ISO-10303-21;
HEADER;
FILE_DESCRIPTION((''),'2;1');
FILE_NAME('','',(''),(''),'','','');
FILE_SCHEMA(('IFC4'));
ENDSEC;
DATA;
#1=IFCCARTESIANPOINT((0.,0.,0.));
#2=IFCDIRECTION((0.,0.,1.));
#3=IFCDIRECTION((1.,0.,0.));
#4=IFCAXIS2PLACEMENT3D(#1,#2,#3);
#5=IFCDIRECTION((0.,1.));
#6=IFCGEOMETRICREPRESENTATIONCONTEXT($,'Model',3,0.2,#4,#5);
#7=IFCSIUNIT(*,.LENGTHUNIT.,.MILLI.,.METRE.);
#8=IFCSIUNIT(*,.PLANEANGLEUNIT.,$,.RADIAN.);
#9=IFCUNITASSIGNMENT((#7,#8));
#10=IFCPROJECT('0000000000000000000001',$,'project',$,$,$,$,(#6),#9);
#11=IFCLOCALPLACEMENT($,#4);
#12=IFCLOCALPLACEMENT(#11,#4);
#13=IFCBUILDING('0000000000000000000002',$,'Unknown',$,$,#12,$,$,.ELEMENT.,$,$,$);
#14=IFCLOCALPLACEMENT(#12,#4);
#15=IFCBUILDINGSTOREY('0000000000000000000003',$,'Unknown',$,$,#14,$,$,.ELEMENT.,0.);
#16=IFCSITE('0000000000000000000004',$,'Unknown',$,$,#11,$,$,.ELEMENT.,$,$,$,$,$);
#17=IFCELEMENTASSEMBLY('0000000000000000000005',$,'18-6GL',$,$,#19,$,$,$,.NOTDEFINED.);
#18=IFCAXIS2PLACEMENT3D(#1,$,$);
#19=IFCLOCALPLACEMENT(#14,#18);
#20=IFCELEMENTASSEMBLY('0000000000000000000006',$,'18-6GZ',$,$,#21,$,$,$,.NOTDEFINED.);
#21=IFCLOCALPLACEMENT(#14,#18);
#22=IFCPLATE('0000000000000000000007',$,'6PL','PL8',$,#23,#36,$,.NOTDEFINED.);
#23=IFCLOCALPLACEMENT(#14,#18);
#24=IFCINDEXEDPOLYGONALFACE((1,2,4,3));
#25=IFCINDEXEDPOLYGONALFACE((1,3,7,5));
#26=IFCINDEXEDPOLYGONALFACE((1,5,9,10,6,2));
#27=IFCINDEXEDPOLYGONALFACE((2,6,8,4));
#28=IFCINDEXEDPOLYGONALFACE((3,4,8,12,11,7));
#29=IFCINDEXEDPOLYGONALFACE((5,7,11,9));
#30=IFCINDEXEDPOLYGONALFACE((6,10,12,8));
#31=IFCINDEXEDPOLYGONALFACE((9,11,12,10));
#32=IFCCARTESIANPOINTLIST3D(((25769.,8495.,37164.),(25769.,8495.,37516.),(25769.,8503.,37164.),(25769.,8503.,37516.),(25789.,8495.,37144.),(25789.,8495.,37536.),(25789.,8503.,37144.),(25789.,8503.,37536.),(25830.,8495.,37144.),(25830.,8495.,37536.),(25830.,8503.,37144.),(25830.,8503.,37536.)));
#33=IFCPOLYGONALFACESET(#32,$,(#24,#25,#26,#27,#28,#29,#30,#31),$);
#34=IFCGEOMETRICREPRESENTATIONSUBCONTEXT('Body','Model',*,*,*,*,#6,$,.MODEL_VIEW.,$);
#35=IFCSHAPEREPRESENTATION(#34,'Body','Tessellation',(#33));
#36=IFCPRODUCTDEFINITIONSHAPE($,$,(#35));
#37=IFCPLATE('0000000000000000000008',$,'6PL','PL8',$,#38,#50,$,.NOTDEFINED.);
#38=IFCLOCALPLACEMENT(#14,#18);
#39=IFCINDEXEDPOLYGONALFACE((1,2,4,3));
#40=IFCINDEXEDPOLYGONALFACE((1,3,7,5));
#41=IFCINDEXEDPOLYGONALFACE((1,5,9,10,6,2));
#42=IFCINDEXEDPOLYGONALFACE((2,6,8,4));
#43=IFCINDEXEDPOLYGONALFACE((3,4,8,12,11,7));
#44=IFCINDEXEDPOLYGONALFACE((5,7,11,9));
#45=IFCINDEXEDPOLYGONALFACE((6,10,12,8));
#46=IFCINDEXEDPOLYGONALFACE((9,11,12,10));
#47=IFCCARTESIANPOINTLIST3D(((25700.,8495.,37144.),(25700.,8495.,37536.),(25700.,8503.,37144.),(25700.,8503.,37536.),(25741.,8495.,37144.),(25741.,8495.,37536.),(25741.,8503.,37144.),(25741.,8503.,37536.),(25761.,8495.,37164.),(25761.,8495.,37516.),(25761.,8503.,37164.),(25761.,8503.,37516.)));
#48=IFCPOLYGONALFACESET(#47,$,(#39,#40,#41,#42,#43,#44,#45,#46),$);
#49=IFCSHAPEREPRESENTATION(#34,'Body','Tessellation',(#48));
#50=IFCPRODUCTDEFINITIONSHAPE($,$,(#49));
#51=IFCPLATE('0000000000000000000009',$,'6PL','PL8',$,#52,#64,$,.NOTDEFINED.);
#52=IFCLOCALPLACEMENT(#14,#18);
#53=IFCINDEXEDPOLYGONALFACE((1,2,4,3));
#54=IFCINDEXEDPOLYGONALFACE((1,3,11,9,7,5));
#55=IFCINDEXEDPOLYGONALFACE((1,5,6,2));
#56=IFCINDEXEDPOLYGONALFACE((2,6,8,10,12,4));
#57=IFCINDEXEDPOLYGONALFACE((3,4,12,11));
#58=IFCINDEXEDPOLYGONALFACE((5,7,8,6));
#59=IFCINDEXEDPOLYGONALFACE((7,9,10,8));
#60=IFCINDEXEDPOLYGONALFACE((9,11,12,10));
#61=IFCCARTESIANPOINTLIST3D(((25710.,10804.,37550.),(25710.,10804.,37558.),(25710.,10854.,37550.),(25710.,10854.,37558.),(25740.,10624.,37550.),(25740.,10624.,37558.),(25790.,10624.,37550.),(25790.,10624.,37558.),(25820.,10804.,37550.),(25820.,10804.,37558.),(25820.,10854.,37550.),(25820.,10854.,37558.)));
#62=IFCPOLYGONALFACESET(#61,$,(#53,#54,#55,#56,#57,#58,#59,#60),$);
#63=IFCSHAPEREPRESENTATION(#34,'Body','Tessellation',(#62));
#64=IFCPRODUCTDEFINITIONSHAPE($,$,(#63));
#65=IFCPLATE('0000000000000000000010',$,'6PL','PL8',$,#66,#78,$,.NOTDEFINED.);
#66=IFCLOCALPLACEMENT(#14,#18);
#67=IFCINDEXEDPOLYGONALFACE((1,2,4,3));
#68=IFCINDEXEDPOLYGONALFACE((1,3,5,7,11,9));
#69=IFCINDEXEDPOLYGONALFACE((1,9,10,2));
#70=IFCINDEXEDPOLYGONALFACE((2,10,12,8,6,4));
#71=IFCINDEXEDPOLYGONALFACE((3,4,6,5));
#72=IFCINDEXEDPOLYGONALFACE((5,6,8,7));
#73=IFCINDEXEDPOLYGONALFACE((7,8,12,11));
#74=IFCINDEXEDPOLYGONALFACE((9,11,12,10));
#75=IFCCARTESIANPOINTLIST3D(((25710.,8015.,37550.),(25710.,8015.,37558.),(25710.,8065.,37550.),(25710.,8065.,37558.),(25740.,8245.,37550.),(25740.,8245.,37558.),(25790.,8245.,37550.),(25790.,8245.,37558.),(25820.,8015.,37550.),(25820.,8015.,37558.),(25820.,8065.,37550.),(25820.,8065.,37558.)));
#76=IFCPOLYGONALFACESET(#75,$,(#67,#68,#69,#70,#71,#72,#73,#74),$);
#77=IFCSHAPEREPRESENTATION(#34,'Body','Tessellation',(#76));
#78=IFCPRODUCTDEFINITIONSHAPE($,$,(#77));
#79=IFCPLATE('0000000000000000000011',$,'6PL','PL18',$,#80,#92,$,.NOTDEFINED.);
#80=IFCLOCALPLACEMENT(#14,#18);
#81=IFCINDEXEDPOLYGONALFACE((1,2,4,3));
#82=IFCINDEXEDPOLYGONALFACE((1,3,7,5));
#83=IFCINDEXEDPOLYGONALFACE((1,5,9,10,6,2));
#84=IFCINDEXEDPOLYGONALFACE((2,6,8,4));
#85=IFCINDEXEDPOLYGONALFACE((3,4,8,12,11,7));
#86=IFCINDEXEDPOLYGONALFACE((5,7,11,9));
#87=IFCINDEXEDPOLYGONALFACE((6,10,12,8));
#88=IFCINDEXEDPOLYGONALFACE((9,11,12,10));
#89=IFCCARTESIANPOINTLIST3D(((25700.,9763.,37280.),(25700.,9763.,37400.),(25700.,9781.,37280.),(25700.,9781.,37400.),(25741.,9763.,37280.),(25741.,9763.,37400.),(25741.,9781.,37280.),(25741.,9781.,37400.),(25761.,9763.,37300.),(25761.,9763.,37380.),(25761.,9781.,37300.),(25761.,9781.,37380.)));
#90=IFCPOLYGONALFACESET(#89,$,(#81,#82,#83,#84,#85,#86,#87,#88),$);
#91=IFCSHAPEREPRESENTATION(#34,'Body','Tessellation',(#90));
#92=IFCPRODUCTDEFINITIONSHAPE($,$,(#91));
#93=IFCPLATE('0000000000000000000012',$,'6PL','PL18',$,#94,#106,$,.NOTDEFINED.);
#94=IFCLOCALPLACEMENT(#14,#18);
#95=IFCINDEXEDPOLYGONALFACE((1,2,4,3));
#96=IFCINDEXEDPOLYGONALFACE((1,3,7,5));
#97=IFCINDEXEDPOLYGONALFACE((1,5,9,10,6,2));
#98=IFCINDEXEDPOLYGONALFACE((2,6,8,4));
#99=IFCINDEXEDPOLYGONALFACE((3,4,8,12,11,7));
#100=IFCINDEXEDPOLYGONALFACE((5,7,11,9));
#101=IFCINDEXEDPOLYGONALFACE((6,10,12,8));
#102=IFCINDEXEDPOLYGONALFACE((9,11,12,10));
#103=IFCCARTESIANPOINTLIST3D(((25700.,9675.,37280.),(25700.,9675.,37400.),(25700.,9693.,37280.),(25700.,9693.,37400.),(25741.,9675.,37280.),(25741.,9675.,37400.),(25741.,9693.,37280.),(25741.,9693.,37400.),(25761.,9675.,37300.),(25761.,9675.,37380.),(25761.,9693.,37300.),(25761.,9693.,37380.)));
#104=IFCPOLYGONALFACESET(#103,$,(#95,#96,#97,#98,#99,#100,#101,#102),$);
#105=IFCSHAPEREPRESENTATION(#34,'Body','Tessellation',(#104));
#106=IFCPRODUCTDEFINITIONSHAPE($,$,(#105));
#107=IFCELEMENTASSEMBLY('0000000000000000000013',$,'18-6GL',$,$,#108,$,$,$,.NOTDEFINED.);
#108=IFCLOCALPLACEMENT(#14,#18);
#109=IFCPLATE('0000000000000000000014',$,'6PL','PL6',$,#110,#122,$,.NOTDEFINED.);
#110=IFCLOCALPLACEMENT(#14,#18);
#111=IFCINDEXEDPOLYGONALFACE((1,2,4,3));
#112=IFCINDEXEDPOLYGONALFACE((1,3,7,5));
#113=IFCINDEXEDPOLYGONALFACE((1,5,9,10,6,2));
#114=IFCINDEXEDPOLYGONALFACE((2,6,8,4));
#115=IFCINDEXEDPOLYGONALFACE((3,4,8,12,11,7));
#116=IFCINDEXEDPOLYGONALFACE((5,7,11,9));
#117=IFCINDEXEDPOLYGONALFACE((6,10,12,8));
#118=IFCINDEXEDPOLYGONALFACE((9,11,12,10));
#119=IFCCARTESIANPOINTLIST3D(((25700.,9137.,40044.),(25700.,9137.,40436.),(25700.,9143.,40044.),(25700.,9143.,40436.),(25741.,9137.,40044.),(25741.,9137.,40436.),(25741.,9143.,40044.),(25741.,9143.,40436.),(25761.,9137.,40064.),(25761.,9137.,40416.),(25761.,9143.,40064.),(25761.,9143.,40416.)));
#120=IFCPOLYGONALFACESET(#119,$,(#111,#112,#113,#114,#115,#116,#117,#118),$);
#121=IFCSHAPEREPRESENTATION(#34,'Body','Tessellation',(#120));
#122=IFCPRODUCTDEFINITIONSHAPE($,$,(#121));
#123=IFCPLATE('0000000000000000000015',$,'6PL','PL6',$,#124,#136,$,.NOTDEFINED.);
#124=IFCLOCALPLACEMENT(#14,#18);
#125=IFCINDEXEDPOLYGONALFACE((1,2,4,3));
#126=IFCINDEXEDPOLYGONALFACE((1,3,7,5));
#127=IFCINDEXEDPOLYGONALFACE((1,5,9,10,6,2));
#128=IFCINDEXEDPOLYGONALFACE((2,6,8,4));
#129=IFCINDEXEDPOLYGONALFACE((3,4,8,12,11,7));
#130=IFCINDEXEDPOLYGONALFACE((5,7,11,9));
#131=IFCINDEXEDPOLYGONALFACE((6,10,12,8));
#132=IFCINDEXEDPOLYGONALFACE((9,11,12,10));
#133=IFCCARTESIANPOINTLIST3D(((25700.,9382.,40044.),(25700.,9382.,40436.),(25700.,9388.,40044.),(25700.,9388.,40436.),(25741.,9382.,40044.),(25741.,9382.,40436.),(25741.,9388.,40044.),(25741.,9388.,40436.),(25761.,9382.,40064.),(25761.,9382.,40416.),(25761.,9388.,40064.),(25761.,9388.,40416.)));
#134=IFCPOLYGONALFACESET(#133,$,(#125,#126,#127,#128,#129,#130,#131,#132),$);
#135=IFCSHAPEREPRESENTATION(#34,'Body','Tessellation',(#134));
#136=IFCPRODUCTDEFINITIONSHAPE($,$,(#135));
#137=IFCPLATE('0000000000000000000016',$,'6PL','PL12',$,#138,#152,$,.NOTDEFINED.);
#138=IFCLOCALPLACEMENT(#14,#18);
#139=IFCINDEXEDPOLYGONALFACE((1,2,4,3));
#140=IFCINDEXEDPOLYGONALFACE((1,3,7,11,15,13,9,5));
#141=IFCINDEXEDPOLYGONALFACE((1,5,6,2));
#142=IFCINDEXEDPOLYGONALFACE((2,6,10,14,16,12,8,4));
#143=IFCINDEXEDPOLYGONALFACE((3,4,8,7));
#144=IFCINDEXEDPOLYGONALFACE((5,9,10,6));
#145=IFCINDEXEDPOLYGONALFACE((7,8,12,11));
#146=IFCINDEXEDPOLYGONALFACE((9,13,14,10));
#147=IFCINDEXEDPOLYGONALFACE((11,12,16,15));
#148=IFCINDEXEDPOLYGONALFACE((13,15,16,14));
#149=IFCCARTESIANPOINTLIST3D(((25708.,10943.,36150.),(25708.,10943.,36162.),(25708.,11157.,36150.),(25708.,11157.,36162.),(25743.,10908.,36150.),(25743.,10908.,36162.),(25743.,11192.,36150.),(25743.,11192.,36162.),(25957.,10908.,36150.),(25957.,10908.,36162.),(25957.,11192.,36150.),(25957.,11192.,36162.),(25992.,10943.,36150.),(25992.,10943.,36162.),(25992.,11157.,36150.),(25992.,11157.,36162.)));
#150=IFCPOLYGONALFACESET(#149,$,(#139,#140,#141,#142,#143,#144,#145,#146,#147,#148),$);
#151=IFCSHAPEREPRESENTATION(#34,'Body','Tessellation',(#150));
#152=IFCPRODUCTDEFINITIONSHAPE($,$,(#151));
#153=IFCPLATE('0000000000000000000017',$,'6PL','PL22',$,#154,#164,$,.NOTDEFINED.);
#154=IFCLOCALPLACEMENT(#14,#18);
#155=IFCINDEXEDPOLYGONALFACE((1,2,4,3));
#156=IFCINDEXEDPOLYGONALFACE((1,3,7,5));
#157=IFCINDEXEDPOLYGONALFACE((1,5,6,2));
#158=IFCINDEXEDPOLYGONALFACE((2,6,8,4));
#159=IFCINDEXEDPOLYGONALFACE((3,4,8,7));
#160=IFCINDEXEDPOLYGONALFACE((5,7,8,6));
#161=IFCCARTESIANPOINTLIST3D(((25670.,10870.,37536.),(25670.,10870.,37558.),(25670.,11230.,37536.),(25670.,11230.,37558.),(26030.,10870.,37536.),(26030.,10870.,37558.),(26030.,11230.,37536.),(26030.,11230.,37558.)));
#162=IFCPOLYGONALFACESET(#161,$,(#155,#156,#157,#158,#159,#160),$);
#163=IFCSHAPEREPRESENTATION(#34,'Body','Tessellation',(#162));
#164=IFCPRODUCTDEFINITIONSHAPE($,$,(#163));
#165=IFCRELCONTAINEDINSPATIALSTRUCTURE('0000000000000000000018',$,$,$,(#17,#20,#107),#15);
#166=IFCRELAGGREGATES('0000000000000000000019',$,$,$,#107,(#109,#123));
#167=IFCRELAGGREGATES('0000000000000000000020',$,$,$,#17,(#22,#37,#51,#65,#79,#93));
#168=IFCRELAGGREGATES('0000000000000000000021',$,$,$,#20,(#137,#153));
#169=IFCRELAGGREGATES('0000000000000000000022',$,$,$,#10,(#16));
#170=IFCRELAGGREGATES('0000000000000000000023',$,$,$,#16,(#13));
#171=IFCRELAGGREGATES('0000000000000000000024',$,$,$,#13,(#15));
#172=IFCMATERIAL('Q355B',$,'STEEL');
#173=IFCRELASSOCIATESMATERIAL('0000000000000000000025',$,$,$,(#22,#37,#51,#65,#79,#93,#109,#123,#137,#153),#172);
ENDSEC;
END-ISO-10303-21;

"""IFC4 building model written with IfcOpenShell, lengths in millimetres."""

from ifc_helpers import new_model, si_unit, direction, frame, origin_with_axes, place, context, subcontext, project, spatial, line, indexed_curve, outline, extrude, material, element, aggregate, save


model = new_model("IFC4")

# Units and contexts
model_context = context("Model", 3, precision=0.2, world=origin_with_axes(), true_north=direction((0.0, 1.0)))
body_context = subcontext(model_context, "Body", "Model", "MODEL_VIEW")
ifc_project = project(units=[si_unit("LENGTHUNIT", "METRE", prefix="MILLI"), si_unit("PLANEANGLEUNIT", "RADIAN")], contexts=[model_context])

# Site, building, storey
site_placement = place(None, origin_with_axes())
site = spatial("IfcSite", under=ifc_project, at=site_placement, Name="Unknown", CompositionType="ELEMENT")
building_placement = place(site_placement, origin_with_axes())
building = spatial("IfcBuilding", under=site, at=building_placement, Name="Unknown", CompositionType="ELEMENT")
storey_placement = place(building_placement, origin_with_axes())
storey = spatial("IfcBuildingStorey", under=building, at=storey_placement, Name="Unknown", CompositionType="ELEMENT", Elevation=0.0)

# Element assembly
assembly_1_placement = place(storey_placement, frame((25765.0, 10900.0, 37340.0), z_axis=(-1.0, 0.0, 0.0), x_axis=(0.0, -1.0, 0.0)))
assembly_1 = element("IfcElementAssembly", 1, at=assembly_1_placement, inside=storey, Name="18-6GL", PredefinedType="NOTDEFINED")
ifc_material_1 = material(Name="Q355B", Category="STEEL")

# Element assembly
assembly_2_placement = place(storey_placement, frame((25850.0, 11050.0, 35950.0), z_axis=(-1.0, 0.0, 0.0), x_axis=(0.0, 0.0, 1.0)))
assembly_2 = element("IfcElementAssembly", 2, at=assembly_2_placement, inside=storey, Name="18-6GZ", PredefinedType="NOTDEFINED")

# Plates
plate_1_placement = place(assembly_1_placement, frame((2401.0, -196.0, -65.0), z_axis=(-1.0, 0.0, 0.0), x_axis=(0.0, 0.0, 1.0)))
plate_1 = element("IfcPlate", 3, at=plate_1_placement, material=ifc_material_1, Name="6PL", Description="PL8", PredefinedType="NOTDEFINED", context=body_context, shape_type="SolidModel", body=[
    extrude(outline(indexed_curve([(0.0, 0.0), (41.0, 0.0), (61.0, 20.0), (61.0, 372.0), (41.0, 392.0), (0.0, 392.0)], segments=[line(1, 2, 3, 4, 5, 6, 1)])), frame((0.0, 0.0, 4.0), z_axis=(0.0, 0.0, 1.0), x_axis=(1.0, 0.0, 0.0)), (0.0, 0.0, -1.0), 8.0),
])
plate_2_placement = place(assembly_1_placement, frame((2401.0, -196.0, 4.0), z_axis=(-1.0, 0.0, 0.0), x_axis=(0.0, 0.0, 1.0)))
plate_2 = element("IfcPlate", 4, at=plate_2_placement, material=ifc_material_1, Name="6PL", Description="PL8", PredefinedType="NOTDEFINED", context=body_context, shape_type="SolidModel", body=[
    extrude(outline(indexed_curve([(0.0, 20.0), (20.0, 0.0), (61.0, 0.0), (61.0, 392.0), (20.0, 392.0), (0.0, 372.0)], segments=[line(1, 2, 3, 4, 5, 6, 1)])), frame((0.0, 0.0, 4.0), z_axis=(0.0, 0.0, 1.0), x_axis=(1.0, 0.0, 0.0)), (0.0, 0.0, -1.0), 8.0),
])
plate_3_placement = place(assembly_1_placement, frame((96.0, 214.0, -55.0), z_axis=(0.0, 1.0, 0.0), x_axis=(-1.0, 0.0, 0.0)))
plate_3 = element("IfcPlate", 5, at=plate_3_placement, material=ifc_material_1, Name="6PL", Description="PL8", PredefinedType="NOTDEFINED", context=body_context, shape_type="SolidModel", body=[
    extrude(outline(indexed_curve([(0.0, 0.0), (50.0, 0.0), (50.0, 110.0), (0.0, 110.0), (-180.0, 80.0), (-180.0, 30.0)], segments=[line(1, 2, 3, 4, 5, 6, 1)])), frame((0.0, 0.0, 4.0), z_axis=(0.0, 0.0, 1.0), x_axis=(1.0, 0.0, 0.0)), (0.0, 0.0, -1.0), 8.0),
])
plate_4_placement = place(assembly_1_placement, frame((2835.0, 214.0, -55.0), z_axis=(0.0, -1.0, 0.0), x_axis=(1.0, 0.0, 0.0)))
plate_4 = element("IfcPlate", 6, at=plate_4_placement, material=ifc_material_1, Name="6PL", Description="PL8", PredefinedType="NOTDEFINED", context=body_context, shape_type="SolidModel", body=[
    extrude(outline(indexed_curve([(0.0, 0.0), (50.0, 0.0), (50.0, 110.0), (0.0, 110.0), (-180.0, 80.0), (-180.0, 30.0)], segments=[line(1, 2, 3, 4, 5, 6, 1)])), frame((0.0, 0.0, 4.0), z_axis=(0.0, 0.0, 1.0), x_axis=(1.0, 0.0, 0.0)), (0.0, 0.0, -1.0), 8.0),
])
plate_5_placement = place(assembly_1_placement, frame((1128.0, -60.0, 65.0), z_axis=(1.0, 0.0, 0.0), x_axis=(0.0, 0.0, -1.0)))
plate_5 = element("IfcPlate", 7, at=plate_5_placement, material=ifc_material_1, Name="6PL", Description="PL18", PredefinedType="NOTDEFINED", context=body_context, shape_type="SolidModel", body=[
    extrude(outline(indexed_curve([(0.0, 0.0), (41.0, 0.0), (61.0, 20.0), (61.0, 100.0), (41.0, 120.0), (0.0, 120.0)], segments=[line(1, 2, 3, 4, 5, 6, 1)])), frame((0.0, 0.0, 9.0), z_axis=(0.0, 0.0, 1.0), x_axis=(1.0, 0.0, 0.0)), (0.0, 0.0, -1.0), 18.0),
])
plate_6_placement = place(assembly_1_placement, frame((1216.0, -60.0, 65.0), z_axis=(1.0, 0.0, 0.0), x_axis=(0.0, 0.0, -1.0)))
plate_6 = element("IfcPlate", 8, at=plate_6_placement, material=ifc_material_1, Name="6PL", Description="PL18", PredefinedType="NOTDEFINED", context=body_context, shape_type="SolidModel", body=[
    extrude(outline(indexed_curve([(0.0, 0.0), (41.0, 0.0), (61.0, 20.0), (61.0, 100.0), (41.0, 120.0), (0.0, 120.0)], segments=[line(1, 2, 3, 4, 5, 6, 1)])), frame((0.0, 0.0, 9.0), z_axis=(0.0, 0.0, 1.0), x_axis=(1.0, 0.0, 0.0)), (0.0, 0.0, -1.0), 18.0),
])

# Element assembly, plates
assembly_3_placement = place(storey_placement, frame((25765.0, 10900.0, 40240.0), z_axis=(-1.0, 0.0, 0.0), x_axis=(0.0, -1.0, 0.0)))
assembly_3 = element("IfcElementAssembly", 9, at=assembly_3_placement, inside=storey, Name="18-6GL", PredefinedType="NOTDEFINED")
plate_7_placement = place(assembly_3_placement, frame((1760.0, -196.0, 4.0), z_axis=(-1.0, 0.0, 0.0), x_axis=(0.0, 0.0, 1.0)))
plate_7 = element("IfcPlate", 10, at=plate_7_placement, material=ifc_material_1, Name="6PL", Description="PL6", PredefinedType="NOTDEFINED", context=body_context, shape_type="SolidModel", body=[
    extrude(outline(indexed_curve([(0.0, 20.0), (20.0, 0.0), (61.0, 0.0), (61.0, 392.0), (20.0, 392.0), (0.0, 372.0)], segments=[line(1, 2, 3, 4, 5, 6, 1)])), frame((0.0, 0.0, 3.0), z_axis=(0.0, 0.0, 1.0), x_axis=(1.0, 0.0, 0.0)), (0.0, 0.0, -1.0), 6.0),
])
plate_8_placement = place(assembly_3_placement, frame((1515.0, -196.0, 4.0), z_axis=(-1.0, 0.0, 0.0), x_axis=(0.0, 0.0, 1.0)))
plate_8 = element("IfcPlate", 11, at=plate_8_placement, material=ifc_material_1, Name="6PL", Description="PL6", PredefinedType="NOTDEFINED", context=body_context, shape_type="SolidModel", body=[
    extrude(outline(indexed_curve([(0.0, 20.0), (20.0, 0.0), (61.0, 0.0), (61.0, 392.0), (20.0, 392.0), (0.0, 372.0)], segments=[line(1, 2, 3, 4, 5, 6, 1)])), frame((0.0, 0.0, 3.0), z_axis=(0.0, 0.0, 1.0), x_axis=(1.0, 0.0, 0.0)), (0.0, 0.0, -1.0), 6.0),
])
aggregate(assembly_3, [plate_7, plate_8])

# Plates
plate_9_placement = place(assembly_2_placement, frame((206.0, -142.0, 142.0), z_axis=(1.0, 0.0, 0.0), x_axis=(0.0, 0.0, -1.0)))
plate_9 = element("IfcPlate", 12, at=plate_9_placement, material=ifc_material_1, Name="6PL", Description="PL12", PredefinedType="NOTDEFINED", context=body_context, shape_type="SolidModel", body=[
    extrude(outline(indexed_curve([(0.0, 35.0), (35.0, 0.0), (249.0, 0.0), (284.0, 35.0), (284.0, 249.0), (249.0, 284.0), (35.0, 284.0), (0.0, 249.0)], segments=[line(1, 2, 3, 4, 5, 6, 7, 8, 1)])), frame((0.0, 0.0, 6.0), z_axis=(0.0, 0.0, 1.0), x_axis=(1.0, 0.0, 0.0)), (0.0, 0.0, -1.0), 12.0),
])
plate_10_placement = place(assembly_2_placement, frame((1597.0, -180.0, 180.0), z_axis=(1.0, 0.0, 0.0), x_axis=(0.0, 0.0, -1.0)))
plate_10 = element("IfcPlate", 13, at=plate_10_placement, material=ifc_material_1, Name="6PL", Description="PL22", PredefinedType="NOTDEFINED", context=body_context, shape_type="SolidModel", body=[
    extrude(outline(indexed_curve([(0.0, 0.0), (360.0, 0.0), (360.0, 360.0), (0.0, 360.0)], segments=[line(1, 2, 3, 4, 1)])), frame((0.0, 0.0, 11.0), z_axis=(0.0, 0.0, 1.0), x_axis=(1.0, 0.0, 0.0)), (0.0, 0.0, -1.0), 22.0),
])

aggregate(assembly_1, [plate_1, plate_2, plate_3, plate_4, plate_5, plate_6])
aggregate(assembly_2, [plate_9, plate_10])

save(model, "model.ifc")
